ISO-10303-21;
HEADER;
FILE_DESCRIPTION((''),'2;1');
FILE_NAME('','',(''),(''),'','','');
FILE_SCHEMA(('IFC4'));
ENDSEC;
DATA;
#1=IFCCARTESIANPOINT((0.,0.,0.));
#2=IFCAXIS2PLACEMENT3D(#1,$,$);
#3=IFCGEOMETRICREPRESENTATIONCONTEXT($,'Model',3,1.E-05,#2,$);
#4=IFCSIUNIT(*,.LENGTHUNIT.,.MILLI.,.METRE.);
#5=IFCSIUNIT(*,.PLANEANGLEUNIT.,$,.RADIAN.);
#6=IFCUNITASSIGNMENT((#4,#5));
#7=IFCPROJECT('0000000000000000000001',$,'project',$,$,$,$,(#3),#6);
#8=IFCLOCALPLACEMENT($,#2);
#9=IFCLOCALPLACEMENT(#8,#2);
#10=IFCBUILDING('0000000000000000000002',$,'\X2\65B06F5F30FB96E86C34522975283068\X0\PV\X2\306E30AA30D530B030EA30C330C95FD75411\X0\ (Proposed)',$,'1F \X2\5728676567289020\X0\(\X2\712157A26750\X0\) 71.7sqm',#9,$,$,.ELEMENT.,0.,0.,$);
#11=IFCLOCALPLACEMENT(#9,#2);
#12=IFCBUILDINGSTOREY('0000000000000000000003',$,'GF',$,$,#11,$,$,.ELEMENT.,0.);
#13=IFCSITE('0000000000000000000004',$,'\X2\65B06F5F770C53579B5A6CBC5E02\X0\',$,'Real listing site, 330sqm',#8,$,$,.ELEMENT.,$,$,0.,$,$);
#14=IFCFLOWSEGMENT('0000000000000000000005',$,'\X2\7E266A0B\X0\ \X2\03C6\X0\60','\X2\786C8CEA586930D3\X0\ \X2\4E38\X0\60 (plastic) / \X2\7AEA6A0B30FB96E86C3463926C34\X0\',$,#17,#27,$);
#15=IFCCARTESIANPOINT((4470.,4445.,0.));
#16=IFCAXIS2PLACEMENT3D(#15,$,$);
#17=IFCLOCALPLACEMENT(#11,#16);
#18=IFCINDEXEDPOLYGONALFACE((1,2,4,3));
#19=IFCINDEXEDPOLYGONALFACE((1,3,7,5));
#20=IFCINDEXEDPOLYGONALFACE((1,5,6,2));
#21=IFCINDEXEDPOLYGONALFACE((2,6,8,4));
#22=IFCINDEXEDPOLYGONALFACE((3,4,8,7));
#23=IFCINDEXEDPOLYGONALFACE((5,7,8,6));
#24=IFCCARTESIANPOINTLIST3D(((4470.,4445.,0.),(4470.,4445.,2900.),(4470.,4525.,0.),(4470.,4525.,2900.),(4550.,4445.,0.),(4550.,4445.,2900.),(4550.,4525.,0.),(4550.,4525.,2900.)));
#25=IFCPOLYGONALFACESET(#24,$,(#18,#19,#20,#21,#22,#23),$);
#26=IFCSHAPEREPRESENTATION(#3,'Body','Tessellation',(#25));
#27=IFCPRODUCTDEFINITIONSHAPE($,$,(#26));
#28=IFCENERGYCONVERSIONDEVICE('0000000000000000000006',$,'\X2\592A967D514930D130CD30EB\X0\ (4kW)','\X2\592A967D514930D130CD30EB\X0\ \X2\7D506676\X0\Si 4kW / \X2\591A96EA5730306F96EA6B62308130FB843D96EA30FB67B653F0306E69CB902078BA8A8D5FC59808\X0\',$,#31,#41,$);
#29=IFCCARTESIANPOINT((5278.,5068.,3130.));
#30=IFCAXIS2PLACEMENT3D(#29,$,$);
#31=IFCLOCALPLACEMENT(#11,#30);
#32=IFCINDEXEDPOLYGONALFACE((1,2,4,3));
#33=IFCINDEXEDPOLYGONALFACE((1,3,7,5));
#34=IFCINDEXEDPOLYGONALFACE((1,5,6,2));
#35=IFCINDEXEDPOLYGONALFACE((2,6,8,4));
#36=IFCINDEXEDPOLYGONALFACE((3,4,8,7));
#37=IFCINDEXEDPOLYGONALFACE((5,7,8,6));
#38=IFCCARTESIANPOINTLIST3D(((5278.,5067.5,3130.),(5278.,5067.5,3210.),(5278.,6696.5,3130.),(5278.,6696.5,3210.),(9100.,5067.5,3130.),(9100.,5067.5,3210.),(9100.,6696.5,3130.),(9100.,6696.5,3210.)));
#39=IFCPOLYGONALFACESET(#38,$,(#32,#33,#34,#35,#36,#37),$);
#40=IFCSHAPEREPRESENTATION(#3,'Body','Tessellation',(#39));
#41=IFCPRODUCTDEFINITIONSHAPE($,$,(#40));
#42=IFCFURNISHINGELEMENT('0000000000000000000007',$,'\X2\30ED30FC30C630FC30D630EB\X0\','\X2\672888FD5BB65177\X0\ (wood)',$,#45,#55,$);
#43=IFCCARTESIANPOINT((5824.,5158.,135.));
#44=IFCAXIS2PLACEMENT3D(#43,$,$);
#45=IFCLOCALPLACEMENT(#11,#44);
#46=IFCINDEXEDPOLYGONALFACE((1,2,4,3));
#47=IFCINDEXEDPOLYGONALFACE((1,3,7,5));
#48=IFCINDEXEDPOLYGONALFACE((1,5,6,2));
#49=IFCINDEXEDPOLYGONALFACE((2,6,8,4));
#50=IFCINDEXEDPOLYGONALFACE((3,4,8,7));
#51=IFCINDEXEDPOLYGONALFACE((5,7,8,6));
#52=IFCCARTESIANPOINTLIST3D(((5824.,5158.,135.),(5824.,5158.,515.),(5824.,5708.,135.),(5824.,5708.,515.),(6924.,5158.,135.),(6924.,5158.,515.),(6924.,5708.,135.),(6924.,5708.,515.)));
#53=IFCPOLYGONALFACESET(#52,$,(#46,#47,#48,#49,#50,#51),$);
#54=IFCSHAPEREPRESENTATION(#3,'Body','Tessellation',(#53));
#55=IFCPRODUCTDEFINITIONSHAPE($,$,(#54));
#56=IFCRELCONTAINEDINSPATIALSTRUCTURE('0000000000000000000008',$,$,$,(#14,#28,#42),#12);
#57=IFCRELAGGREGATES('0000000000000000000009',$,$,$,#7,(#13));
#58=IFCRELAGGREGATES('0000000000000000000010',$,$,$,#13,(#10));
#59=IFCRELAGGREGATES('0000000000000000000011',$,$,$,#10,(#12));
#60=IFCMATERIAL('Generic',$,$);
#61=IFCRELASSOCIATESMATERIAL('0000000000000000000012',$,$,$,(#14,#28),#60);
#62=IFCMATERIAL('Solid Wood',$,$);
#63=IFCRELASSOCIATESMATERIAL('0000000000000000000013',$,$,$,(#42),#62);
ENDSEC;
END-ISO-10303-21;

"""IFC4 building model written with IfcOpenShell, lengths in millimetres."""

from ifc_helpers import new_model, si_unit, frame, frame_2d, origin, place, context, project, spatial, rectangle, extrude, material, element, save


model = new_model("IFC4")

# Units and contexts
model_context = context("Model", 3, precision=1e-05, world=origin())
ifc_project = project(units=[si_unit("LENGTHUNIT", "METRE", prefix="MILLI"), si_unit("PLANEANGLEUNIT", "RADIAN")], contexts=[model_context])

# Site, building, storey
site_placement = place(None, origin())
site = spatial("IfcSite", under=ifc_project, at=site_placement, Name="新潟県南魚沼市", ObjectType="Real listing site, 330sqm", CompositionType="ELEMENT", RefElevation=0.0)
building_placement = place(site_placement, origin())
building = spatial("IfcBuilding", under=site, at=building_placement, Name="新潟・雨水利用とPVのオフグリッド志向 (Proposed)", ObjectType="1F 在来木造(無垢材) 71.7sqm", CompositionType="ELEMENT", ElevationOfRefHeight=0.0, ElevationOfTerrain=0.0)
storey_placement = place(building_placement, origin())
storey = spatial("IfcBuildingStorey", under=building, at=storey_placement, Name="GF", CompositionType="ELEMENT", Elevation=0.0)

# Shared definitions
ifc_material_1 = material(Name="Solid Wood")

# Shared definitions
ifc_material_2 = material(Name="Generic")

# Flow segment
flow_segment_1_placement = place(storey_placement, frame((4470.0, 4445.0, 0.0)))
element("IfcFlowSegment", 1, at=flow_segment_1_placement, inside=storey, material=ifc_material_2, Name="縦樋 φ60", Description="硬質塩ビ 丸60 (plastic) / 竪樋・雨水排水", context=model_context, shape_type="SweptSolid", body=[
    extrude(rectangle(XDim=80.0, YDim=80.0, at=frame_2d((40.0, 40.0))), frame((4470.0, 4445.0, 0.0)), (0.0, 0.0, 1.0), 2900.0),
])

# Energy conversion device
energy_conversion_device_placement = place(storey_placement, frame((5278.0, 5068.0, 3130.0)))
element("IfcEnergyConversionDevice", 2, at=energy_conversion_device_placement, inside=storey, material=ifc_material_2, Name="太陽光パネル (4kW)", Description="太陽光パネル 結晶Si 4kW / 多雪地は雪止め・落雪・架台の構造確認必須", context=model_context, shape_type="SweptSolid", body=[
    extrude(rectangle(XDim=3822.0, YDim=1629.0, at=frame_2d((1911.0, 814.0))), frame((5278.0, 5068.0, 3130.0)), (0.0, 0.0, 1.0), 80.0),
])

# Furnishing element
furnishing_placement = place(storey_placement, frame((5824.0, 5158.0, 135.0)))
element("IfcFurnishingElement", 3, at=furnishing_placement, inside=storey, material=ifc_material_1, Name="ローテーブル", Description="木製家具 (wood)", context=model_context, shape_type="SweptSolid", body=[
    extrude(rectangle(XDim=1100.0, YDim=550.0, at=frame_2d((550.0, 275.0))), frame((5824.0, 5158.0, 135.0)), (0.0, 0.0, 1.0), 380.0),
])

save(model, "model.ifc")
